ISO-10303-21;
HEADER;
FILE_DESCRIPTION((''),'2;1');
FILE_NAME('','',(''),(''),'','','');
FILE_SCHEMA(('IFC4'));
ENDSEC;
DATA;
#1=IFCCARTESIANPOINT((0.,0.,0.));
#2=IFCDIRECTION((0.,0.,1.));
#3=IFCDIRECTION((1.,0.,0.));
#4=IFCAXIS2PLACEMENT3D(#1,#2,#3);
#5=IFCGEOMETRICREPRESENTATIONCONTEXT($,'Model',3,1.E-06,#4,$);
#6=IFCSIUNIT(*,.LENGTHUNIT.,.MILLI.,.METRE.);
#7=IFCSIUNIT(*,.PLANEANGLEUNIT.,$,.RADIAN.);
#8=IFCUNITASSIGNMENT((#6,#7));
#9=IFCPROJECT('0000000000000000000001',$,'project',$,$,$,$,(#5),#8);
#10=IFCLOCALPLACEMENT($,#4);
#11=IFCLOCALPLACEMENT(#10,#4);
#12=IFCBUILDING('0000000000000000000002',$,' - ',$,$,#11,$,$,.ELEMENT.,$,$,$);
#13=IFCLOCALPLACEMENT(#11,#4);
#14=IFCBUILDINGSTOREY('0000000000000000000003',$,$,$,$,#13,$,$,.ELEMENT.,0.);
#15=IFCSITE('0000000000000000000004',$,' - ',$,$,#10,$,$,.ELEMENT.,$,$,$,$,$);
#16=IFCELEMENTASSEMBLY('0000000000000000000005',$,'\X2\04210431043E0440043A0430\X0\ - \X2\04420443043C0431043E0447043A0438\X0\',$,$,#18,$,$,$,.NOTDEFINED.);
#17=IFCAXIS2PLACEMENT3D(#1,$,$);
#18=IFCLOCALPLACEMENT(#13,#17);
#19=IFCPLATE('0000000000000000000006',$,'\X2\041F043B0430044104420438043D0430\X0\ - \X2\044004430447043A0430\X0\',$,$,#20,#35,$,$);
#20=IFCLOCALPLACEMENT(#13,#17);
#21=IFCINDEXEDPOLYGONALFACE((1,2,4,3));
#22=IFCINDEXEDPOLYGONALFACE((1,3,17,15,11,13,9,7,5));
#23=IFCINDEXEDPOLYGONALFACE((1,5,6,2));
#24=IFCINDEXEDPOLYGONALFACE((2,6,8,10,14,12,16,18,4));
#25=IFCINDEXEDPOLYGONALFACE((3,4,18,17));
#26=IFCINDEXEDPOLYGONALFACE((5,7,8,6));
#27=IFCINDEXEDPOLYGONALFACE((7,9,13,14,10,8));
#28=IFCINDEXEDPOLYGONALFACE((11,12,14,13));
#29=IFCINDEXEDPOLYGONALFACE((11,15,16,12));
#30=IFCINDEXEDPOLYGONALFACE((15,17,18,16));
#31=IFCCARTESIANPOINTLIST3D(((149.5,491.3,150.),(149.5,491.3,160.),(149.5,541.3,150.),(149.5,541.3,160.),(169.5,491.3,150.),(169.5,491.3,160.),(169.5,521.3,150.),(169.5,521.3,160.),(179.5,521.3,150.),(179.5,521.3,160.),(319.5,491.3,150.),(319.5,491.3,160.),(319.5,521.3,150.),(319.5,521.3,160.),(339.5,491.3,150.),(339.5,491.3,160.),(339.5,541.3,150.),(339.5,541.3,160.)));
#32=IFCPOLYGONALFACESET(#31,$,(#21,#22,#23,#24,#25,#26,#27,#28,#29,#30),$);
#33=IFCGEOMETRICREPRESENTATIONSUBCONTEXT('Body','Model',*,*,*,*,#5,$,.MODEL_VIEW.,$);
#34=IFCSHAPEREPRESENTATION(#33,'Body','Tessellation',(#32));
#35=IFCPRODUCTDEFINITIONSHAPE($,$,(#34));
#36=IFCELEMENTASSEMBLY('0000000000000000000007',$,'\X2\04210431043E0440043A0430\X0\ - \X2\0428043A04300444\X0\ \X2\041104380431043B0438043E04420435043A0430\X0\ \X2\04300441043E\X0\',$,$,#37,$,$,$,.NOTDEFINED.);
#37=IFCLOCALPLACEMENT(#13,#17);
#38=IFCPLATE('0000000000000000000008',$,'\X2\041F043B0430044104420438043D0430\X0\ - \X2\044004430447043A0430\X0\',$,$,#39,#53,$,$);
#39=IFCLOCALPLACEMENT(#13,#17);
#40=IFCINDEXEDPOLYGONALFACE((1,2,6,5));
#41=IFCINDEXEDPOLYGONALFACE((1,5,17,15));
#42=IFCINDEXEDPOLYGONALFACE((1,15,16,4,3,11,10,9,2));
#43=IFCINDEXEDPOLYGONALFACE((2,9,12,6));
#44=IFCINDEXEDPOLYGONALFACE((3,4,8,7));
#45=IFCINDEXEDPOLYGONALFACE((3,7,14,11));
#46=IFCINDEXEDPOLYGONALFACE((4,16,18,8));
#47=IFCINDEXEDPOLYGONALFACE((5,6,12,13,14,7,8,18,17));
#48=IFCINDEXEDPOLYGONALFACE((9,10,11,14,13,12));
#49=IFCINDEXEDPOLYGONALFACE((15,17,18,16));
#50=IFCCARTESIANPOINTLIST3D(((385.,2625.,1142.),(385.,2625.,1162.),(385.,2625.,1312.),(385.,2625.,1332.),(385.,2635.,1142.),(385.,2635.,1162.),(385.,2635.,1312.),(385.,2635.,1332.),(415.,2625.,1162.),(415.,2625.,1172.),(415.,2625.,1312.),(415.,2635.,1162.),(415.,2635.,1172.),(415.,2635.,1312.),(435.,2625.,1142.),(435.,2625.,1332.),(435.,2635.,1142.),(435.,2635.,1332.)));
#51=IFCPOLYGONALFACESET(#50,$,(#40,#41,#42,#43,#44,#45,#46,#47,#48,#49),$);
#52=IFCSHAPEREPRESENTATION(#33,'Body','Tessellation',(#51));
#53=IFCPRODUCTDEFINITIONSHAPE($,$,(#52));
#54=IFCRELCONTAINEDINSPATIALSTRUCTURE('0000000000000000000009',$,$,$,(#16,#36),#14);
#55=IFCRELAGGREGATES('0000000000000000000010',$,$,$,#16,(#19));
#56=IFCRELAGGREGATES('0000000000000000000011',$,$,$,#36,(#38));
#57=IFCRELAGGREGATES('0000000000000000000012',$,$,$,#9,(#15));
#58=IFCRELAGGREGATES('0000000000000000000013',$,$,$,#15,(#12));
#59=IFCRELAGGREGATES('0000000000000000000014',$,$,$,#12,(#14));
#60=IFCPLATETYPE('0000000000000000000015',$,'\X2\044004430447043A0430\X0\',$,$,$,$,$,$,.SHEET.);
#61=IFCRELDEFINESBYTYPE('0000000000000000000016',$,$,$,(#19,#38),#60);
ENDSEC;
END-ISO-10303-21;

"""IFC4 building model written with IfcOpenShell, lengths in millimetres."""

from ifc_helpers import new_model, si_unit, frame, origin_with_axes, place, context, subcontext, project, spatial, line, indexed_curve, outline, extrude, source, transform, mapped, type_object, element, aggregate, save


model = new_model("IFC4")

# Units and contexts
model_context = context("Model", 3, precision=1e-06, world=origin_with_axes())
body_context = subcontext(model_context, "Body", "Model", "MODEL_VIEW")
ifc_project = project(units=[si_unit("LENGTHUNIT", "METRE", prefix="MILLI"), si_unit("PLANEANGLEUNIT", "RADIAN")], contexts=[model_context])

# Site, building, storey
site_placement = place(None, origin_with_axes())
site = spatial("IfcSite", under=ifc_project, at=site_placement, Name=" - ", CompositionType="ELEMENT")
building_placement = place(site_placement, origin_with_axes())
building = spatial("IfcBuilding", under=site, at=building_placement, Name=" - ", CompositionType="ELEMENT")
storey_placement = place(building_placement, origin_with_axes())
storey = spatial("IfcBuildingStorey", under=building, at=storey_placement, CompositionType="ELEMENT", Elevation=0.0)

# Shared definitions
plate_type = type_object("IfcPlateType", Name="ручка", PredefinedType="SHEET")
shared_shape_1 = source(origin_with_axes(), body_context, "Body", "SweptSolid", [
    extrude(outline(indexed_curve([(-95.0, -25.0), (-75.0, -25.0), (-75.0, 5.0), (-65.0, 5.0), (75.0, 5.0), (75.0, -25.0), (95.0, -25.0), (95.0, 25.0), (-95.0, 25.0)], segments=[line(1, 2), line(2, 3), line(3, 4), line(4, 5), line(5, 6), line(6, 7), line(7, 8), line(8, 9), line(9, 1)])), origin_with_axes(), (0.0, 0.0, 1.0), 10.0),
])

# Element assembly, plate
assembly_1_placement = place(storey_placement, frame((444.5, 491.3, 0.0), z_axis=(0.0, 0.0, 1.0), x_axis=(-1.0, 0.0, 0.0)))
assembly_1 = element("IfcElementAssembly", 1, at=assembly_1_placement, inside=storey, Name="Сборка - тумбочки", PredefinedType="NOTDEFINED")
plate_1_placement = place(assembly_1_placement, frame((200.0, -25.0, 150.0), z_axis=(0.0, 0.0, 1.0), x_axis=(-1.0, 0.0, 0.0)))
plate_1 = element("IfcPlate", 2, at=plate_1_placement, type_object=plate_type, Name="Пластина - ручка", context=body_context, shape_type="MappedRepresentation", body=[
    mapped(shared_shape_1, transform((0.0, 0.0, 0.0), x_axis=(1.0, 0.0, 0.0), y_axis=(0.0, 1.0, 0.0), z_axis=(0.0, 0.0, 1.0), scale=1.0)),
])
aggregate(assembly_1, [plate_1])

# Element assembly, plate
assembly_2_placement = place(storey_placement, frame((400.0, 2580.0, 2.0), z_axis=(0.0, 0.0, 1.0), x_axis=(0.0, 1.0, 0.0)))
assembly_2 = element("IfcElementAssembly", 3, at=assembly_2_placement, inside=storey, Name="Сборка - Шкаф Библиотека асо", PredefinedType="NOTDEFINED")
shared_shape_2 = source(origin_with_axes(), body_context, "Body", "SweptSolid", [
    extrude(outline(indexed_curve([(-95.0, -25.0), (-75.0, -25.0), (-75.0, 5.0), (-65.0, 5.0), (75.0, 5.0), (75.0, -25.0), (95.0, -25.0), (95.0, 25.0), (-95.0, 25.0)], segments=[line(1, 2), line(2, 3), line(3, 4), line(4, 5), line(5, 6), line(6, 7), line(7, 8), line(8, 9), line(9, 1)])), origin_with_axes(), (0.0, 0.0, 1.0), 10.0),
])
plate_2_placement = place(assembly_2_placement, frame((45.0, -10.0, 1235.0), z_axis=(1.0, 0.0, 0.0), x_axis=(0.0, 0.0, 1.0)))
plate_2 = element("IfcPlate", 4, at=plate_2_placement, type_object=plate_type, Name="Пластина - ручка", context=body_context, shape_type="MappedRepresentation", body=[
    mapped(shared_shape_2, transform((0.0, 0.0, 0.0), x_axis=(1.0, 0.0, 0.0), y_axis=(0.0, 1.0, 0.0), z_axis=(0.0, 0.0, 1.0), scale=1.0)),
])
aggregate(assembly_2, [plate_2])

save(model, "model.ifc")
